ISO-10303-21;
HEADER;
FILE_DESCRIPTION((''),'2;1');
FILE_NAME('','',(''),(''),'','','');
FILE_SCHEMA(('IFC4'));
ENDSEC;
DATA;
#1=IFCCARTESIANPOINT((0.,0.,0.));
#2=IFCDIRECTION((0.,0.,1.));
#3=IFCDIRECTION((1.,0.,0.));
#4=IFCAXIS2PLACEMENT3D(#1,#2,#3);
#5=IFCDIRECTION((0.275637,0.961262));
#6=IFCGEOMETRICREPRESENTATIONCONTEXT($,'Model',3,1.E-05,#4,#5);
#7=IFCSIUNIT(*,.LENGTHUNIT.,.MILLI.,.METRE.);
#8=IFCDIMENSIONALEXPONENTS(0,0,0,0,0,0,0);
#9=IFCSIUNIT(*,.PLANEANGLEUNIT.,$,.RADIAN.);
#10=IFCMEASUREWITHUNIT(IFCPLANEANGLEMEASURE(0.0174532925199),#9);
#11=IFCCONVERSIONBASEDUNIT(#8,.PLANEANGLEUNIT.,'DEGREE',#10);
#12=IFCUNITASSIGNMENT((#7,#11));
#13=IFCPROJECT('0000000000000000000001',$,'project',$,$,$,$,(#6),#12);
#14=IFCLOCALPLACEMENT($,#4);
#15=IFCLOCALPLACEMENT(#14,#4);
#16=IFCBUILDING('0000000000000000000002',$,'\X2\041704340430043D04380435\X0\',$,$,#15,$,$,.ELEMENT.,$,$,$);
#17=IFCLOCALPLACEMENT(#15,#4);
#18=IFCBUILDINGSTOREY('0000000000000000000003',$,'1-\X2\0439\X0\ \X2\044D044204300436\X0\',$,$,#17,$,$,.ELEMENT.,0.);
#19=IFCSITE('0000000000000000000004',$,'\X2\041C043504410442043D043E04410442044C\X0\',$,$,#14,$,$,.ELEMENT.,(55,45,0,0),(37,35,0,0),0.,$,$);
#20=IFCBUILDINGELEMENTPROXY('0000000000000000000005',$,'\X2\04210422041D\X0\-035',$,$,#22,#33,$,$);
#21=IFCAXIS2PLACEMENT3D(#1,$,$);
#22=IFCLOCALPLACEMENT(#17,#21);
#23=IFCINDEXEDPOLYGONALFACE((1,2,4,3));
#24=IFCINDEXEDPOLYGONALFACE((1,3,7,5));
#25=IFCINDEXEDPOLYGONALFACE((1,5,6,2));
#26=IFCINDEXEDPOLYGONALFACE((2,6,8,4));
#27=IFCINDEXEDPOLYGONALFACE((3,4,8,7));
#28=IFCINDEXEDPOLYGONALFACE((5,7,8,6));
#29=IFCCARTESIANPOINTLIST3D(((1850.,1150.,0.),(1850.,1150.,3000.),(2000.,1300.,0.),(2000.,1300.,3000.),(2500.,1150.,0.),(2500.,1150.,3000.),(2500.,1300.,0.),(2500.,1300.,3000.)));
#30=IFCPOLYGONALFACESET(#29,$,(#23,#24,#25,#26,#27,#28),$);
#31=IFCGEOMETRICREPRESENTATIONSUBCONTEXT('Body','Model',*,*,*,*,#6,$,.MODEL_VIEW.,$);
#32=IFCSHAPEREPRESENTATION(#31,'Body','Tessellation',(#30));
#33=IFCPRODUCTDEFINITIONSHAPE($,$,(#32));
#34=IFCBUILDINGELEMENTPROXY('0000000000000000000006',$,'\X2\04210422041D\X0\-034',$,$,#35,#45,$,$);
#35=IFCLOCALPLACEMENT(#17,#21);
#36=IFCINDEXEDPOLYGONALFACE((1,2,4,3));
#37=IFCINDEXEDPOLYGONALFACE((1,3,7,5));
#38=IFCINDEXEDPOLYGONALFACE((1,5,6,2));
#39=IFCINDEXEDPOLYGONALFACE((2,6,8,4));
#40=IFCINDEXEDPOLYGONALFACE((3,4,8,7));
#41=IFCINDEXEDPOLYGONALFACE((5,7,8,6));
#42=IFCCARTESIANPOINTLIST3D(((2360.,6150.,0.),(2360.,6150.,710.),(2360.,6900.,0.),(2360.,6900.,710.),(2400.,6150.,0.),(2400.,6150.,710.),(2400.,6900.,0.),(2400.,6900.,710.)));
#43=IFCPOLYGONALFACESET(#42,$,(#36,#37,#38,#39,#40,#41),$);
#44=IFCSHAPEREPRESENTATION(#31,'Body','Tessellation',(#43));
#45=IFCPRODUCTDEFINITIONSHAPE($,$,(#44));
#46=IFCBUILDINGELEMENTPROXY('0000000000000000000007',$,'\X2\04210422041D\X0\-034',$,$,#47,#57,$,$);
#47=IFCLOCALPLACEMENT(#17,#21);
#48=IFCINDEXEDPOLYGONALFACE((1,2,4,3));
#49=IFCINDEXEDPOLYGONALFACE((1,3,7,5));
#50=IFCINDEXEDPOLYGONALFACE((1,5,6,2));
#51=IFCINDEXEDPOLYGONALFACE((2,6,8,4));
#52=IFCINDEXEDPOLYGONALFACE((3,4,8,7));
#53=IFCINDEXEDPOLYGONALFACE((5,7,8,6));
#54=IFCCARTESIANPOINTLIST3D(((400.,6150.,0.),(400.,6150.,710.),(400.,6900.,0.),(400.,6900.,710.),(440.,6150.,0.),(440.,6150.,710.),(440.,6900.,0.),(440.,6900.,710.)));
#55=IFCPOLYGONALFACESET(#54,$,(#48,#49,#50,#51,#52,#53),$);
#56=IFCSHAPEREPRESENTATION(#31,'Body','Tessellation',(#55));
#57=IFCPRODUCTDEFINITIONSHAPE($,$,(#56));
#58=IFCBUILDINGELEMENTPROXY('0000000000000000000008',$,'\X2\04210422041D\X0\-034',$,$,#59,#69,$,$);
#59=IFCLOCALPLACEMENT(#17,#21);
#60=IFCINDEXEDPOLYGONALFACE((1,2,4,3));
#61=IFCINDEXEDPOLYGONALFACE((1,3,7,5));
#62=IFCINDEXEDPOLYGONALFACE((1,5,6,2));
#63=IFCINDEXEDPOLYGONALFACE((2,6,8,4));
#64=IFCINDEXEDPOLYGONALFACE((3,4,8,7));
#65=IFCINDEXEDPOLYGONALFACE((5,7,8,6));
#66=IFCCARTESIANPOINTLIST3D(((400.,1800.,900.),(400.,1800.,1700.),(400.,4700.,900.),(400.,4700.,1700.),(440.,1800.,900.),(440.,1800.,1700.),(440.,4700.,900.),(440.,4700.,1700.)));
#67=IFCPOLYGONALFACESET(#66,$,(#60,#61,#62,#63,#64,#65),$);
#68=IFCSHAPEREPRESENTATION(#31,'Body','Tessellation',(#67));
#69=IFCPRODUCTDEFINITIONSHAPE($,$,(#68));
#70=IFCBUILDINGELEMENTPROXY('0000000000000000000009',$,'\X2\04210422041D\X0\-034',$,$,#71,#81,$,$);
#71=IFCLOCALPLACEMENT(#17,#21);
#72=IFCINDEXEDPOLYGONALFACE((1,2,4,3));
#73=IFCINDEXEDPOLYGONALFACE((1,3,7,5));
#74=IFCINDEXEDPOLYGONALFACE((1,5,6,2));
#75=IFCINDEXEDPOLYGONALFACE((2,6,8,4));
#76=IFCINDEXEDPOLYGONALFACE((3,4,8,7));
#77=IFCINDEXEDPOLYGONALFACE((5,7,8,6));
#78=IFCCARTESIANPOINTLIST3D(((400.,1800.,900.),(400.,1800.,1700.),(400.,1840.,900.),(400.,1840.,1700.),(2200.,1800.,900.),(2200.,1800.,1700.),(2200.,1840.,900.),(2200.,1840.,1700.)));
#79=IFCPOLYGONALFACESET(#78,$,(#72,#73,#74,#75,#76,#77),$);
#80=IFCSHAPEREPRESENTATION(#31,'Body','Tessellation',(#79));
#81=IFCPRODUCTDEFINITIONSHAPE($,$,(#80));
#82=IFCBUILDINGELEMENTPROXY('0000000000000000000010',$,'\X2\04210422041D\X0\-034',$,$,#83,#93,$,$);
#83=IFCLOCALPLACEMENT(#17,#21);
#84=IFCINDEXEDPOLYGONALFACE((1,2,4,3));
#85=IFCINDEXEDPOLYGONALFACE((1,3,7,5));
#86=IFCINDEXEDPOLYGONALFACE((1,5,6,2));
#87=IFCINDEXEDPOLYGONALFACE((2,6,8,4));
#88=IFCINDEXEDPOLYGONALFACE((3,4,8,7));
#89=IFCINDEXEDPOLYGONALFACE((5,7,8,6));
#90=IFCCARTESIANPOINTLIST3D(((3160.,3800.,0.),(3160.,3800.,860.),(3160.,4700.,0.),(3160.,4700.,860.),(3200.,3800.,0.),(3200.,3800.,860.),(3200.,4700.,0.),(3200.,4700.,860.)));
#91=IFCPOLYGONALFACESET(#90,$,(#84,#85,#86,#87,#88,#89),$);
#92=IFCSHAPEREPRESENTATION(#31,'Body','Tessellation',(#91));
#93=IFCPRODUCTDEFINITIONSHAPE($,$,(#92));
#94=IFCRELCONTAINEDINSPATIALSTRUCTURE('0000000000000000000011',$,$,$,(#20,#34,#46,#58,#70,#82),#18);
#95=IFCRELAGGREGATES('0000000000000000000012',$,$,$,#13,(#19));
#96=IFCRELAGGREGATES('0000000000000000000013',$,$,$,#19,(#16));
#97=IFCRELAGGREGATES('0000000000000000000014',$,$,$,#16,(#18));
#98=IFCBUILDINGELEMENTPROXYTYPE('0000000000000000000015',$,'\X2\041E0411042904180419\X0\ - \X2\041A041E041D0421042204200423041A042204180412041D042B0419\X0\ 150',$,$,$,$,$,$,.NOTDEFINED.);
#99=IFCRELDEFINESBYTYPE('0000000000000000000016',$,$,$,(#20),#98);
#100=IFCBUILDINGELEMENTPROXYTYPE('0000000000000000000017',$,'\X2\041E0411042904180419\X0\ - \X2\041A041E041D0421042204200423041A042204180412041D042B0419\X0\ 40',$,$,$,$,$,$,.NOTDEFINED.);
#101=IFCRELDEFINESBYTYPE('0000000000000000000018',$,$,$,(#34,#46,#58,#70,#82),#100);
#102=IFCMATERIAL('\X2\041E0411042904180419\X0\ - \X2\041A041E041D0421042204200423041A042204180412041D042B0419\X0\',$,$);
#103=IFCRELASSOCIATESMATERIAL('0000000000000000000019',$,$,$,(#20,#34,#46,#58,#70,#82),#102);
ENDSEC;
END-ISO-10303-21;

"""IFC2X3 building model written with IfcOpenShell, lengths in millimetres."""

from ifc_helpers import new_model, entity, si_unit, converted_unit, direction, frame, origin_with_axes, place, context, subcontext, project, spatial, polyline, outline, extrude, material, type_object, element, save


model = new_model("IFC2X3")

# Units and contexts
model_context = context("Model", 3, precision=1e-05, world=origin_with_axes(), true_north=direction((0.275637, 0.961262)))
body_context = subcontext(model_context, "Body", "Model", "MODEL_VIEW")
ifc_project = project(units=[si_unit("LENGTHUNIT", "METRE", prefix="MILLI"), converted_unit("PLANEANGLEUNIT", "DEGREE", entity("IfcPlaneAngleMeasure", 0.0174532925199), si_unit("PLANEANGLEUNIT", "RADIAN"), dimensions=[0, 0, 0, 0, 0, 0, 0])], contexts=[model_context])

# Site, building, storey
site_placement = place(None, origin_with_axes())
site = spatial("IfcSite", under=ifc_project, at=site_placement, Name="Местность", CompositionType="ELEMENT", RefLatitude=(55, 45, 0, 0), RefLongitude=(37, 35, 0, 0), RefElevation=0.0)
building_placement = place(site_placement, origin_with_axes())
building = spatial("IfcBuilding", under=site, at=building_placement, Name="Здание", CompositionType="ELEMENT")
storey_placement = place(building_placement, origin_with_axes())
storey = spatial("IfcBuildingStorey", under=building, at=storey_placement, Name="1-й этаж", CompositionType="ELEMENT", Elevation=0.0)

# Shared definitions
ifc_material_1 = material(Name="ОБЩИЙ - КОНСТРУКТИВНЫЙ")

# Shared definitions
building_element_proxy_type_1 = type_object("IfcBuildingElementProxyType", Name="ОБЩИЙ - КОНСТРУКТИВНЫЙ 150", PredefinedType="NOTDEFINED")

# Building element proxies
proxy_1_placement = place(storey_placement, frame((2000.0, 1300.0, 0.0), z_axis=(0.0, 0.0, 1.0), x_axis=(1.0, 0.0, 0.0)))
element("IfcBuildingElementProxy", 1, at=proxy_1_placement, inside=storey, type_object=building_element_proxy_type_1, material=ifc_material_1, Name="СТН-035", context=body_context, shape_type="SweptSolid", body=[
    extrude(outline(polyline([(-150.0, -150.0), (500.0, -150.0), (500.0, 0.0), (0.0, 0.0), (-150.0, -150.0)])), origin_with_axes(), (0.0, 0.0, 1.0), 3000.0),
])
building_element_proxy_type_2 = type_object("IfcBuildingElementProxyType", Name="ОБЩИЙ - КОНСТРУКТИВНЫЙ 40", PredefinedType="NOTDEFINED")
proxy_2_placement = place(storey_placement, frame((2400.0, 6150.0, 0.0), z_axis=(0.0, 0.0, 1.0), x_axis=(0.0, 1.0, 0.0)))
element("IfcBuildingElementProxy", 2, at=proxy_2_placement, inside=storey, type_object=building_element_proxy_type_2, material=ifc_material_1, Name="СТН-034", context=body_context, shape_type="SweptSolid", body=[
    extrude(outline(polyline([(0.0, 0.0), (750.0, 0.0), (750.0, 40.0), (0.0, 40.0), (0.0, 0.0)])), origin_with_axes(), (0.0, 0.0, 1.0), 710.0),
])
proxy_3_placement = place(storey_placement, frame((400.0, 6150.0, 0.0), z_axis=(0.0, 0.0, 1.0), x_axis=(0.0, 1.0, 0.0)))
element("IfcBuildingElementProxy", 3, at=proxy_3_placement, inside=storey, type_object=building_element_proxy_type_2, material=ifc_material_1, Name="СТН-034", context=body_context, shape_type="SweptSolid", body=[
    extrude(outline(polyline([(0.0, -40.0), (750.0, -40.0), (750.0, 0.0), (0.0, 0.0), (0.0, -40.0)])), origin_with_axes(), (0.0, 0.0, 1.0), 710.0),
])
proxy_4_placement = place(storey_placement, frame((400.0, 1800.0, 900.0), z_axis=(0.0, 0.0, 1.0), x_axis=(0.0, 1.0, 0.0)))
element("IfcBuildingElementProxy", 4, at=proxy_4_placement, inside=storey, type_object=building_element_proxy_type_2, material=ifc_material_1, Name="СТН-034", context=body_context, shape_type="SweptSolid", body=[
    extrude(outline(polyline([(0.0, -40.0), (2900.0, -40.0), (2900.0, 0.0), (0.0, 0.0), (0.0, -40.0)])), origin_with_axes(), (0.0, 0.0, 1.0), 800.0),
])
proxy_5_placement = place(storey_placement, frame((2200.0, 1800.0, 900.0), z_axis=(0.0, 0.0, 1.0), x_axis=(-1.0, 0.0, 0.0)))
element("IfcBuildingElementProxy", 5, at=proxy_5_placement, inside=storey, type_object=building_element_proxy_type_2, material=ifc_material_1, Name="СТН-034", context=body_context, shape_type="SweptSolid", body=[
    extrude(outline(polyline([(0.0, -40.0), (1800.0, -40.0), (1800.0, 0.0), (0.0, 0.0), (0.0, -40.0)])), origin_with_axes(), (0.0, 0.0, 1.0), 800.0),
])
proxy_6_placement = place(storey_placement, frame((3200.0, 3800.0, 0.0), z_axis=(0.0, 0.0, 1.0), x_axis=(0.0, 1.0, 0.0)))
element("IfcBuildingElementProxy", 6, at=proxy_6_placement, inside=storey, type_object=building_element_proxy_type_2, material=ifc_material_1, Name="СТН-034", context=body_context, shape_type="SweptSolid", body=[
    extrude(outline(polyline([(0.0, 0.0), (900.0, 0.0), (900.0, 40.0), (0.0, 40.0), (0.0, 0.0)])), origin_with_axes(), (0.0, 0.0, 1.0), 860.0),
])

save(model, "model.ifc")
